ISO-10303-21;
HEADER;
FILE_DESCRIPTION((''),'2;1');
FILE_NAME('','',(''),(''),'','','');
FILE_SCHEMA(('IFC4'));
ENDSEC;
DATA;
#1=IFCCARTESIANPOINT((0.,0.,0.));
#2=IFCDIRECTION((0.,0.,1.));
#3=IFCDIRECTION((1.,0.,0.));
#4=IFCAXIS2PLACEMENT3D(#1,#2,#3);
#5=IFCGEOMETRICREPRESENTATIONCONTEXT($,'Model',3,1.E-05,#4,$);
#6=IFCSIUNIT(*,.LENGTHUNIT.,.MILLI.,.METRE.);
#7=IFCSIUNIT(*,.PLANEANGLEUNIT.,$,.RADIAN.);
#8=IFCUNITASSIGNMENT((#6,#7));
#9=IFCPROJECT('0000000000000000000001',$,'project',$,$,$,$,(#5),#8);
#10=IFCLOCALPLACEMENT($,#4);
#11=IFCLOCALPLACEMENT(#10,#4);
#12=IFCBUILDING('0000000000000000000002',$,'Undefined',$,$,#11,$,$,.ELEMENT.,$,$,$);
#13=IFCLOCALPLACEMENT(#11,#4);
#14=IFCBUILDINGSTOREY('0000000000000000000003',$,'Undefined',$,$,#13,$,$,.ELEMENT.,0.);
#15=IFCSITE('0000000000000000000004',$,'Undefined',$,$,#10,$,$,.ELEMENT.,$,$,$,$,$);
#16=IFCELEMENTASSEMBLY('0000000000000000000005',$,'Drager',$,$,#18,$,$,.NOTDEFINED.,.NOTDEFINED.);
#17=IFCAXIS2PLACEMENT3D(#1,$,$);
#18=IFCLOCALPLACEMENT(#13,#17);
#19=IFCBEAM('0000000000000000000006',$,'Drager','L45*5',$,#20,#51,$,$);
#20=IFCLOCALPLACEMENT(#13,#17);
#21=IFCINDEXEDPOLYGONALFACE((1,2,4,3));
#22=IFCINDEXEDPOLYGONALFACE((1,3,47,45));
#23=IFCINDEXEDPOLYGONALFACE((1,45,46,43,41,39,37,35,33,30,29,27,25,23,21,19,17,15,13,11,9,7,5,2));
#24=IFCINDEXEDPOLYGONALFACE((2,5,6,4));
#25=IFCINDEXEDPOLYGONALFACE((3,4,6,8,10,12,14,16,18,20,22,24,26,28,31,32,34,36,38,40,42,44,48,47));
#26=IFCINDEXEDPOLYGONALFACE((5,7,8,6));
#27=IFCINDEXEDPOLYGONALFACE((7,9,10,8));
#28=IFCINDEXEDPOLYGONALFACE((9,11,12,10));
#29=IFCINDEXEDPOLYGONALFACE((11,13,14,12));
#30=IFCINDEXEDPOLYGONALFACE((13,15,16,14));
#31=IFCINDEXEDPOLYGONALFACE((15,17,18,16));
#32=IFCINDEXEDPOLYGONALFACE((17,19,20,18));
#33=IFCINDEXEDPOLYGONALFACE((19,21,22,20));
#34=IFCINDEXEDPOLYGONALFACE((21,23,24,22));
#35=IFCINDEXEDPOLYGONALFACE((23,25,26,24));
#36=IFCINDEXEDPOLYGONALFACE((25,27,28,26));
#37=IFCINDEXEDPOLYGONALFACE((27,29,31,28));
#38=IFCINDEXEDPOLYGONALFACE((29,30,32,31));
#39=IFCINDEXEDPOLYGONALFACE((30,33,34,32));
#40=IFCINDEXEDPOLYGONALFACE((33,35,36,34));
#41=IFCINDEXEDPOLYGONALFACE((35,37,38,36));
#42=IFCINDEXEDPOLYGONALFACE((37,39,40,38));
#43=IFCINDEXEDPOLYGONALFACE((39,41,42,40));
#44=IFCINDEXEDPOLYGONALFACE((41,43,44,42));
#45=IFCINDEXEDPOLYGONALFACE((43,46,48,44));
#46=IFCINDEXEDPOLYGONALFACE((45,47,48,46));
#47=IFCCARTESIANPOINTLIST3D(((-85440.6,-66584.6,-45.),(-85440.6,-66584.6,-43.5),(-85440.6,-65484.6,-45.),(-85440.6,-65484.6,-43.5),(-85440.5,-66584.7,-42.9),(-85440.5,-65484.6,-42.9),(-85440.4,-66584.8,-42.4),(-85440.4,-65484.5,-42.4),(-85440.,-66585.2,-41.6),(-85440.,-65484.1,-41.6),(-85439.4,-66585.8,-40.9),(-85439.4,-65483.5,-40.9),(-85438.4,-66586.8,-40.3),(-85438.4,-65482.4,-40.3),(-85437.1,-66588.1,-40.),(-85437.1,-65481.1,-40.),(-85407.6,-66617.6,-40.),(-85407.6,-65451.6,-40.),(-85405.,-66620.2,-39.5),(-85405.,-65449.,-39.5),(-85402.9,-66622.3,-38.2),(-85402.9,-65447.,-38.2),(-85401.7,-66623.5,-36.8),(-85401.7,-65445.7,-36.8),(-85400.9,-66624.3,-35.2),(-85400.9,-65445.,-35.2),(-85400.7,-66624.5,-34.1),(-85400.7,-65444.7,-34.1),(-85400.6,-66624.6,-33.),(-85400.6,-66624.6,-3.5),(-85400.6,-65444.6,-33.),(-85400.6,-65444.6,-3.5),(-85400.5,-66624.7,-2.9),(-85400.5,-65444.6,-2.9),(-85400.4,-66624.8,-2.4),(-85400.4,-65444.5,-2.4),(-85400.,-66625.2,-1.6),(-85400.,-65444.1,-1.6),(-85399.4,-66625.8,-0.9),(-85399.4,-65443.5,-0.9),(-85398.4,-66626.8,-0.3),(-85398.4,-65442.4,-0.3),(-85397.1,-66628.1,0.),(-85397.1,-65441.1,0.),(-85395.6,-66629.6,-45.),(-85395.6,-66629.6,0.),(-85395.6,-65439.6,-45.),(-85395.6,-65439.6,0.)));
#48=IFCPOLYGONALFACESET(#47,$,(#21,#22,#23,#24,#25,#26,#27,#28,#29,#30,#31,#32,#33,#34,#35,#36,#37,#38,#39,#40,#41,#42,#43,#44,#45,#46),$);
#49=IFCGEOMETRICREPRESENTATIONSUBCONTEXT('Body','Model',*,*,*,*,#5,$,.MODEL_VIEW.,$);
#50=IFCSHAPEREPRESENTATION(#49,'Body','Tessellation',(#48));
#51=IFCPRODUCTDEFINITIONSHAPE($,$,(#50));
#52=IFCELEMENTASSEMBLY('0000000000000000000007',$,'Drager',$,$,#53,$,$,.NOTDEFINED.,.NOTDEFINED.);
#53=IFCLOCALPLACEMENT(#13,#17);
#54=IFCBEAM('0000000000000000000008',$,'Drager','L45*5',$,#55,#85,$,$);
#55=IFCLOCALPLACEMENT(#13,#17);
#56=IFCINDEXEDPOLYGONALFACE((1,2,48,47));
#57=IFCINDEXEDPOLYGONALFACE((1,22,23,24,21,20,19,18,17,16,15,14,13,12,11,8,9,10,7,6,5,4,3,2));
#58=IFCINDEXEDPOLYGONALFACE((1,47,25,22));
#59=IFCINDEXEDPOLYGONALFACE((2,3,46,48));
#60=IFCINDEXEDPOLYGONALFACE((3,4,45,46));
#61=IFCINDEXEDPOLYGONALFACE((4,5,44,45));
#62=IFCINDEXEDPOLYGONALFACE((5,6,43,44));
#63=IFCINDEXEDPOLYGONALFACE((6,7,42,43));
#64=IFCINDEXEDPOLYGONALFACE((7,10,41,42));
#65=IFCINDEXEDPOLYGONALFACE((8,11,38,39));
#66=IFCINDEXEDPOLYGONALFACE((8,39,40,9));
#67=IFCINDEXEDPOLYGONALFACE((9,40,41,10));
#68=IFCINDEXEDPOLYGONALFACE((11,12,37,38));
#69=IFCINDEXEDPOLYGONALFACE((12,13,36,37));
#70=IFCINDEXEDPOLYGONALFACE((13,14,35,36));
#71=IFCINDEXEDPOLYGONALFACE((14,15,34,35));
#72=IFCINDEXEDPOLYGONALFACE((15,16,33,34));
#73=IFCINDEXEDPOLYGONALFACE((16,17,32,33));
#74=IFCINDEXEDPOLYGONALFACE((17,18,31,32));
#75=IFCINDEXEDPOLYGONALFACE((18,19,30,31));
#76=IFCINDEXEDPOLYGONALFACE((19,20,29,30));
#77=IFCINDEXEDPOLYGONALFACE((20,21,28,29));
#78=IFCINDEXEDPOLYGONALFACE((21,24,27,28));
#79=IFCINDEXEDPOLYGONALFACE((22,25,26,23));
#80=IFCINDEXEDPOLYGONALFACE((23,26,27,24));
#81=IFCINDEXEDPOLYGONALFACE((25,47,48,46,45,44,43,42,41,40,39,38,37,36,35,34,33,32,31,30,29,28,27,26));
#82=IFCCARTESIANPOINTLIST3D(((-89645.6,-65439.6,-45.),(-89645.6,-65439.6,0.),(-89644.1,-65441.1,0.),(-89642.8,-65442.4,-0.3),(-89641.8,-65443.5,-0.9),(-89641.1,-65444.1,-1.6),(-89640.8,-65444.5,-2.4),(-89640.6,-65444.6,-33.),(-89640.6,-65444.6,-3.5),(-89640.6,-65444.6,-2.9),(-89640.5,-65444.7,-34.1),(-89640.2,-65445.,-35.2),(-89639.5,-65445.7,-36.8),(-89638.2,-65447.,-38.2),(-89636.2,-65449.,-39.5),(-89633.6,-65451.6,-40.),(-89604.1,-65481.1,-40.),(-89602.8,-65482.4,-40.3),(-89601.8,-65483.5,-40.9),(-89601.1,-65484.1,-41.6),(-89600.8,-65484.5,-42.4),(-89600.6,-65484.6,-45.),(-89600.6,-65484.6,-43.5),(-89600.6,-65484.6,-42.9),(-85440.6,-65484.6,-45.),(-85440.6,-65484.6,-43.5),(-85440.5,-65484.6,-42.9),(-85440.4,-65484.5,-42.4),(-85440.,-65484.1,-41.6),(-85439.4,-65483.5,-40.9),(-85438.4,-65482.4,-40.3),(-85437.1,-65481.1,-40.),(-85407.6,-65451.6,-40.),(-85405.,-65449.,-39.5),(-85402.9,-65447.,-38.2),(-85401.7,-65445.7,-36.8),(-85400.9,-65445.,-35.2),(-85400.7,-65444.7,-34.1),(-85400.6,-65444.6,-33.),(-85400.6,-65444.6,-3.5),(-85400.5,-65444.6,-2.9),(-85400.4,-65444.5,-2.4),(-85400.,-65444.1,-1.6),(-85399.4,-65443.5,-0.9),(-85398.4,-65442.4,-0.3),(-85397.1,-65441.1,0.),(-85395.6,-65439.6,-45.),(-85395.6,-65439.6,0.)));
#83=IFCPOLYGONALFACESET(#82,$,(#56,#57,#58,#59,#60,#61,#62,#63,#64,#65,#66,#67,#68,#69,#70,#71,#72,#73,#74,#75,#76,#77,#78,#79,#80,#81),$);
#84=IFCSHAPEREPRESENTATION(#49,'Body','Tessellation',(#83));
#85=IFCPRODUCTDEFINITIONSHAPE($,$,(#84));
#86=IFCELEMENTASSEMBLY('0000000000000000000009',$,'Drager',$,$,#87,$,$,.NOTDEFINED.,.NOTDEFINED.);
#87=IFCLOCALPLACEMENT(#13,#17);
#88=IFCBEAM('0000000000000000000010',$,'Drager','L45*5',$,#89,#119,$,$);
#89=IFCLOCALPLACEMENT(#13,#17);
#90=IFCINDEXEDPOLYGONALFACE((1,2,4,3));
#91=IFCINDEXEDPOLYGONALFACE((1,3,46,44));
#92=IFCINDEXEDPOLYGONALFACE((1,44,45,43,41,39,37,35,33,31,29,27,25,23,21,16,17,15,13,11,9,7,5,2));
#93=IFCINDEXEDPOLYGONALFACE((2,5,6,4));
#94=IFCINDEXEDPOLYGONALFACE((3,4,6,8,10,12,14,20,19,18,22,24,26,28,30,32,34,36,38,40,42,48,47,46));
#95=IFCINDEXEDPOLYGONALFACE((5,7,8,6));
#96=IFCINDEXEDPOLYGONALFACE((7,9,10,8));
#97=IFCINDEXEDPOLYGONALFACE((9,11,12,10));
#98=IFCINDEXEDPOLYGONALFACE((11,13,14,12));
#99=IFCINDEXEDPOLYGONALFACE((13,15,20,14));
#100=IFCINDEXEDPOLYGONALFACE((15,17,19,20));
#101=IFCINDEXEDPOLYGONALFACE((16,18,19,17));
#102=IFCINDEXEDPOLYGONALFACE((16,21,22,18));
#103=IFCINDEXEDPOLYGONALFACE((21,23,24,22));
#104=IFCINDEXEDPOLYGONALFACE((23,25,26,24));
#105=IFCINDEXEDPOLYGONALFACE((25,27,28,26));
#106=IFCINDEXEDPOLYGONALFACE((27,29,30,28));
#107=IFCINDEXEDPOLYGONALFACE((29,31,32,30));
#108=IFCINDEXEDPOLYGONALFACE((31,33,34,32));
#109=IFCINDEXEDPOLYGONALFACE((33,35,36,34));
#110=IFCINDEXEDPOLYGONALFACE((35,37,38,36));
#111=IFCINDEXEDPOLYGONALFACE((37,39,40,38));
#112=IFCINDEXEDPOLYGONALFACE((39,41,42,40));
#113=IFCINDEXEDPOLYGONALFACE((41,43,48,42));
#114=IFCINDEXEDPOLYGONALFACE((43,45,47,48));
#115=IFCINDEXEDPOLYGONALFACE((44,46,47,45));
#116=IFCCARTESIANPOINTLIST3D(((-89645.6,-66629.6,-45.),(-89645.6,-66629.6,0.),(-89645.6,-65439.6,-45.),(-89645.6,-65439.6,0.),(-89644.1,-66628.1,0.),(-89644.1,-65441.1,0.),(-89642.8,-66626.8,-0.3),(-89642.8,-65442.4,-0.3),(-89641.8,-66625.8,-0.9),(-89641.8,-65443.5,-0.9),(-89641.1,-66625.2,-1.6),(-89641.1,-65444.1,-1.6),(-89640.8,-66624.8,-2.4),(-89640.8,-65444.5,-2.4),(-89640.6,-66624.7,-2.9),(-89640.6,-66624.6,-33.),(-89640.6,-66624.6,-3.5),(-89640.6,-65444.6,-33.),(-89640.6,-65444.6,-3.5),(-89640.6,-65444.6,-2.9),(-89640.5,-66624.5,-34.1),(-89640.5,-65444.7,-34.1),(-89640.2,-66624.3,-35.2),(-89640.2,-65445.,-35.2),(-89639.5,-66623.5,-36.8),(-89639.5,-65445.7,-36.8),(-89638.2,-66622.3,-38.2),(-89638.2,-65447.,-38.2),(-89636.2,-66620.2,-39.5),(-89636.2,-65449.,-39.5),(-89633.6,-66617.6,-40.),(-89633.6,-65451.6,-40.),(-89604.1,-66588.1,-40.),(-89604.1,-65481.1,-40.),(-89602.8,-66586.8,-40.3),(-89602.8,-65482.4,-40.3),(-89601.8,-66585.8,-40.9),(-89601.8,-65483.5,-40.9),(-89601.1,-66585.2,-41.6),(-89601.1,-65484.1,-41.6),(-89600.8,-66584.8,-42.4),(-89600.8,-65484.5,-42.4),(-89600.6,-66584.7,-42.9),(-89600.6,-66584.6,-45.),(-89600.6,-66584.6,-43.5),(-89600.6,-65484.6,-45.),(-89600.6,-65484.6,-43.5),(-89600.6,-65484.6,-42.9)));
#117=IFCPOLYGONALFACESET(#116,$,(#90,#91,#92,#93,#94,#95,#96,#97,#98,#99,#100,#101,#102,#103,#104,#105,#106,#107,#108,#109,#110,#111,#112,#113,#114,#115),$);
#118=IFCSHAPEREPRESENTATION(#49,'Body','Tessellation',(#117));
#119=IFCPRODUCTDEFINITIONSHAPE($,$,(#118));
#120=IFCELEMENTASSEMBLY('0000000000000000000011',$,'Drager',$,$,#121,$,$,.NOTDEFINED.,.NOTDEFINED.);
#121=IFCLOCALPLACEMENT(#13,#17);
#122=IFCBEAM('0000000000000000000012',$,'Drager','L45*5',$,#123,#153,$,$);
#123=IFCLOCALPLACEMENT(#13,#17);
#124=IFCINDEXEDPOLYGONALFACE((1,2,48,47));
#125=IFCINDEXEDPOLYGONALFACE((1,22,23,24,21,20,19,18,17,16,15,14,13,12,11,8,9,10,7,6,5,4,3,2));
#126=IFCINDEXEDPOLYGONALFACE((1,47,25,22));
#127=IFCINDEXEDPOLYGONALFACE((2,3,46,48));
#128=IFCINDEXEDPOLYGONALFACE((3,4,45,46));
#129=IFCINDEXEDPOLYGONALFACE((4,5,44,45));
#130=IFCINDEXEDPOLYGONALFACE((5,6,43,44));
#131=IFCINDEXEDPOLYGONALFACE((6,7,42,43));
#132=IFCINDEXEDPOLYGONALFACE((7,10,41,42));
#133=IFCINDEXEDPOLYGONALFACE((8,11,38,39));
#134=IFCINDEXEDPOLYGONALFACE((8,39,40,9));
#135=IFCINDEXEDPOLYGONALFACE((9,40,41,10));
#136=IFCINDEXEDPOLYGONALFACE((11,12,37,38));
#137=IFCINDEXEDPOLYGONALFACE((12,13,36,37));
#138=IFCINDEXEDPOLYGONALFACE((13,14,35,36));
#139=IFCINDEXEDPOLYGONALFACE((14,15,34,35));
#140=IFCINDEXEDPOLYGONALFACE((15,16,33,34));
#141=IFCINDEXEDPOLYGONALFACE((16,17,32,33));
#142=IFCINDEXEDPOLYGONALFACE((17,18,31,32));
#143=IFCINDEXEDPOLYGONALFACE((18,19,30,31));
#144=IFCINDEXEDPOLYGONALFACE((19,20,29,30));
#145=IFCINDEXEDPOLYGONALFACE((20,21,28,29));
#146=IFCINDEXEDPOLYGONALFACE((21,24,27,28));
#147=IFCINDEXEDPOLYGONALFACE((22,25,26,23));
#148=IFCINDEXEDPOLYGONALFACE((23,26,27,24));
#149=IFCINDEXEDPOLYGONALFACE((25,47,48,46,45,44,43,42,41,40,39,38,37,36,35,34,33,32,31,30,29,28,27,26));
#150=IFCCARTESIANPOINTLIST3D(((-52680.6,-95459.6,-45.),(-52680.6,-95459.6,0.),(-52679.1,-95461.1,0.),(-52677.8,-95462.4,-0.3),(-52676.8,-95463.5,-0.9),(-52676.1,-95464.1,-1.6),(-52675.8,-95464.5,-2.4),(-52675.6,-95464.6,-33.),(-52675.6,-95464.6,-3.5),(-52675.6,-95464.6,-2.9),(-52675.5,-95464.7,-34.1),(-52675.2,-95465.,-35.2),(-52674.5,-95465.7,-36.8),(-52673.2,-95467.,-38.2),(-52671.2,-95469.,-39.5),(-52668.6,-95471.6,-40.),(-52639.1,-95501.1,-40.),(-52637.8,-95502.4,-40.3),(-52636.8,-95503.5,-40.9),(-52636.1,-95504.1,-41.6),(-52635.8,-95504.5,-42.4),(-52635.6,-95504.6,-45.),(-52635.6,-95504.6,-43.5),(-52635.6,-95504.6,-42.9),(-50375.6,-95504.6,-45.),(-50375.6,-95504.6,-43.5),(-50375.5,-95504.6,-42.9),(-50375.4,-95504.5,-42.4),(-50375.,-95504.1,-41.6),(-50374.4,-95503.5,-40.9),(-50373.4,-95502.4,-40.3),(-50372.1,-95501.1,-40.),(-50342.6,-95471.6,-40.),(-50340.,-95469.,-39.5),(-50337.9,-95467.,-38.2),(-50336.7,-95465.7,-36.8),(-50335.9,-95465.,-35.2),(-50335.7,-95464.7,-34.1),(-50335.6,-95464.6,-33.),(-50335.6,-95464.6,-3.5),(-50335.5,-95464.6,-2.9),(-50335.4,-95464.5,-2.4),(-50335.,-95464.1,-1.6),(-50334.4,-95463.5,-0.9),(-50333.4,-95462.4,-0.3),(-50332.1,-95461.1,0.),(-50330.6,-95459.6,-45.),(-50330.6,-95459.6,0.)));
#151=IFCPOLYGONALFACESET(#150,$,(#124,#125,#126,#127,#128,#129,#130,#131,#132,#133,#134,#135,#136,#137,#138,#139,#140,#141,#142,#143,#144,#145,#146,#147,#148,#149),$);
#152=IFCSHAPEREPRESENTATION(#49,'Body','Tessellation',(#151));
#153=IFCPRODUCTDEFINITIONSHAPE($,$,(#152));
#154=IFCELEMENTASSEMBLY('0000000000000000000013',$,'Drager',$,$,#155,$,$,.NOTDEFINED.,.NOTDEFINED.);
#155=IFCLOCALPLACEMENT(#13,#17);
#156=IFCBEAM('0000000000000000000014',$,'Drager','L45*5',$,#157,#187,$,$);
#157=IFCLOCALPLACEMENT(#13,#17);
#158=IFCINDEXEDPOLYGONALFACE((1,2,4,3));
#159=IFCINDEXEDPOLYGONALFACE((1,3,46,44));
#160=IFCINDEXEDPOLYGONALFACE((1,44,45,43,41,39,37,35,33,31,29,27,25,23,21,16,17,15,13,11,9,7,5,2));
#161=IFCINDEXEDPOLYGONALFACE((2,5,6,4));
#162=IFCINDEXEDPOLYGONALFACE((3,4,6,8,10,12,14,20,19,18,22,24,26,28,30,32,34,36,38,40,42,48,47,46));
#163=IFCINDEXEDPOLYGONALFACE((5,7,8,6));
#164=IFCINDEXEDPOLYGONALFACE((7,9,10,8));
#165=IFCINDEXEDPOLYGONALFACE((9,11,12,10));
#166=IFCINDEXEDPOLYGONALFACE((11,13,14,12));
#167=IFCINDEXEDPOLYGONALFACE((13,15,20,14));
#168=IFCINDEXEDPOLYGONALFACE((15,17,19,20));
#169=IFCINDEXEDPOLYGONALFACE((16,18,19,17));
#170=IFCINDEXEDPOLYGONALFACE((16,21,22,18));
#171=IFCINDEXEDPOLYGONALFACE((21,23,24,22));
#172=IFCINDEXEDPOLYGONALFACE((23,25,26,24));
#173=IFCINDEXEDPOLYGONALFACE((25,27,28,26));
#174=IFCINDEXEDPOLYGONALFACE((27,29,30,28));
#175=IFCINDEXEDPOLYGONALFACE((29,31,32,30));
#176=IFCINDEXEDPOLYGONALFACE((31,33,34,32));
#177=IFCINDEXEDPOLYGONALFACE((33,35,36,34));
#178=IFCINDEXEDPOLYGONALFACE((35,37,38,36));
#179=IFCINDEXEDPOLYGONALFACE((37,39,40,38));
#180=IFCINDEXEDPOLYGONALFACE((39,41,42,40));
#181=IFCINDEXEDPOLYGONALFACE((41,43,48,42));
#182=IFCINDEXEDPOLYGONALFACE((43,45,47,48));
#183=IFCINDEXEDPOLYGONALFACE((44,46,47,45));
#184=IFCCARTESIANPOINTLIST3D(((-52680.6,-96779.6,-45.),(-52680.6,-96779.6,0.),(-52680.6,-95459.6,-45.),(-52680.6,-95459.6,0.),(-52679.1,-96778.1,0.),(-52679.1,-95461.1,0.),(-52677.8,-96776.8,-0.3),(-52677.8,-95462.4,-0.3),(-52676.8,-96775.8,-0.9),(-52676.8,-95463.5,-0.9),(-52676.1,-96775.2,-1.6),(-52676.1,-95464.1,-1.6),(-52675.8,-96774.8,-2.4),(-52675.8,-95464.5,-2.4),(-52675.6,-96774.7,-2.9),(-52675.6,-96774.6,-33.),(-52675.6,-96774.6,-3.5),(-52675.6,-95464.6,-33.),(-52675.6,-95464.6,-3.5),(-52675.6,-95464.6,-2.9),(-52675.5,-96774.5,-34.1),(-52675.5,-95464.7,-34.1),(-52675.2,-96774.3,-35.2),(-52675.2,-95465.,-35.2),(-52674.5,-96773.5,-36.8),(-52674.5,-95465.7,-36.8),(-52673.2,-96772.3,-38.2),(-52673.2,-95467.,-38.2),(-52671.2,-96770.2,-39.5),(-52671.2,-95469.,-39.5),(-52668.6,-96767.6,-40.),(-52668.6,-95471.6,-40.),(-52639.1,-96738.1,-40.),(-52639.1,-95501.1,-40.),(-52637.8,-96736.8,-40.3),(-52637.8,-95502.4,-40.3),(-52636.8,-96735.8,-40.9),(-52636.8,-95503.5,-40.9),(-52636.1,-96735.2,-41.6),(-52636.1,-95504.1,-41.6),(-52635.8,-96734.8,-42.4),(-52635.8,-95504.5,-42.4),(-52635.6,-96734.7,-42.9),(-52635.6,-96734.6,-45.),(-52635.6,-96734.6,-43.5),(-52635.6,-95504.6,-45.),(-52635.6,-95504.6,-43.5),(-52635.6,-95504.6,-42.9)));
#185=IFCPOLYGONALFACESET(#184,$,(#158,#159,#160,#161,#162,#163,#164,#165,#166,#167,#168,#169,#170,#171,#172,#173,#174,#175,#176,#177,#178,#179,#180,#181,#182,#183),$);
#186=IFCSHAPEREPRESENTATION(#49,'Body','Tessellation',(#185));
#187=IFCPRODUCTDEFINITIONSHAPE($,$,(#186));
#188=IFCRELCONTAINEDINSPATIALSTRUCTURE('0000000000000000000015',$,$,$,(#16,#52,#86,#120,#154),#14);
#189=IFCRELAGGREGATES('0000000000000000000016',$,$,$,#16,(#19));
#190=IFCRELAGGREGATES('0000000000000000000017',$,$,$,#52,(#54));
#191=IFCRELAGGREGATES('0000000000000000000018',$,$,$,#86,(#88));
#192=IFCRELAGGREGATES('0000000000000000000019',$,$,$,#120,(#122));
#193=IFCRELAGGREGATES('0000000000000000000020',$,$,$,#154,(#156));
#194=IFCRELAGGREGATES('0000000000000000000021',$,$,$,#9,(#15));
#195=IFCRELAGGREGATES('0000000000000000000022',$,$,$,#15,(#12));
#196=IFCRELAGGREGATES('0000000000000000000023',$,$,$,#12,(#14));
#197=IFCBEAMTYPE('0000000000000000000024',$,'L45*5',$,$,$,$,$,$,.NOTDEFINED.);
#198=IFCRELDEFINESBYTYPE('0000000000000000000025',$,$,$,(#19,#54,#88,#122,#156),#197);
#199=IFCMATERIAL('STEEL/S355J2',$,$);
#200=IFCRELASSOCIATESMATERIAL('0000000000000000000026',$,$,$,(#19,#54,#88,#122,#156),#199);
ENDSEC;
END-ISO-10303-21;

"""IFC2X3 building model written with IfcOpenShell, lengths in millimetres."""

from ifc_helpers import new_model, si_unit, frame, origin_with_axes, origin_2d_with_axis, place, context, subcontext, project, spatial, l_section, extrude, clip, halfspace, material, type_object, element, aggregate, save


model = new_model("IFC2X3")

# Units and contexts
model_context = context("Model", 3, precision=1e-05, world=origin_with_axes())
body_context = subcontext(model_context, "Body", "Model", "MODEL_VIEW")
ifc_project = project(units=[si_unit("LENGTHUNIT", "METRE", prefix="MILLI"), si_unit("PLANEANGLEUNIT", "RADIAN")], contexts=[model_context])

# Site, building, storey
site_placement = place(None, origin_with_axes())
site = spatial("IfcSite", under=ifc_project, at=site_placement, Name="Undefined", CompositionType="ELEMENT")
building_placement = place(site_placement, origin_with_axes())
building = spatial("IfcBuilding", under=site, at=building_placement, Name="Undefined", CompositionType="ELEMENT")
storey_placement = place(building_placement, origin_with_axes())
storey = spatial("IfcBuildingStorey", under=building, at=storey_placement, Name="Undefined", CompositionType="ELEMENT", Elevation=0.0)

# Shared definitions
ifc_material_1 = material(Name="STEEL/S355J2")

# Element assemblies, beams
beam_type_1 = type_object("IfcBeamType", Name="L45*5", PredefinedType="NOTDEFINED")
assembly_1_placement = place(storey_placement, origin_with_axes())
assembly_1 = element("IfcElementAssembly", 1, at=assembly_1_placement, inside=storey, Name="Drager", AssemblyPlace="NOTDEFINED", PredefinedType="NOTDEFINED")
beam_1_placement = place(assembly_1_placement, frame((-85418.1, -65484.6, -22.5), z_axis=(0.0, 0.0, 1.0), x_axis=(0.0, -1.0, 0.0)))
beam_1 = element("IfcBeam", 2, at=beam_1_placement, type_object=beam_type_1, material=ifc_material_1, Name="Drager", Description="L45*5", context=body_context, shape_type="Clipping", body=[
    clip(clip(extrude(l_section(Depth=45.0, Width=45.0, Thickness=5.0, FilletRadius=7.0, EdgeRadius=3.5, at=origin_2d_with_axis()), frame((1167.9, 0.0, 0.0), z_axis=(-1.0, 0.0, 0.0), x_axis=(0.0, -1.0, 0.0)), (0.0, 0.0, 1.0), 1235.9), halfspace(frame((1100.0, -22.5, 22.5), z_axis=(0.707107, -0.707107, 0.0), x_axis=(0.0, 0.0, 1.0)), False)), halfspace(frame((0.0, -22.5, 22.5), z_axis=(0.707107, 0.707107, 0.0), x_axis=(0.0, 0.0, 1.0)), True)),
])
aggregate(assembly_1, [beam_1])
assembly_2_placement = place(storey_placement, origin_with_axes())
assembly_2 = element("IfcElementAssembly", 3, at=assembly_2_placement, inside=storey, Name="Drager", AssemblyPlace="NOTDEFINED", PredefinedType="NOTDEFINED")
beam_2_placement = place(assembly_2_placement, frame((-89600.6, -65462.1, -22.5), z_axis=(0.0, 0.0, 1.0), x_axis=(1.0, 0.0, 0.0)))
beam_2 = element("IfcBeam", 4, at=beam_2_placement, type_object=beam_type_1, material=ifc_material_1, Name="Drager", Description="L45*5", context=body_context, shape_type="Clipping", body=[
    clip(clip(extrude(l_section(Depth=45.0, Width=45.0, Thickness=5.0, FilletRadius=7.0, EdgeRadius=3.5, at=origin_2d_with_axis()), frame((4227.9, 0.0, 0.0), z_axis=(-1.0, 0.0, 0.0), x_axis=(0.0, -1.0, 0.0)), (0.0, 0.0, 1.0), 4295.9), halfspace(frame((4160.0, -22.5, 22.5), z_axis=(0.707107, -0.707107, 0.0), x_axis=(0.0, 0.0, 1.0)), False)), halfspace(frame((0.0, -22.5, 22.5), z_axis=(0.707107, 0.707107, 0.0), x_axis=(0.0, 0.0, 1.0)), True)),
])
aggregate(assembly_2, [beam_2])
assembly_3_placement = place(storey_placement, origin_with_axes())
assembly_3 = element("IfcElementAssembly", 5, at=assembly_3_placement, inside=storey, Name="Drager", AssemblyPlace="NOTDEFINED", PredefinedType="NOTDEFINED")
beam_3_placement = place(assembly_3_placement, frame((-89623.1, -66584.6, -22.5), z_axis=(0.0, 0.0, 1.0), x_axis=(0.0, 1.0, 0.0)))
beam_3 = element("IfcBeam", 6, at=beam_3_placement, type_object=beam_type_1, material=ifc_material_1, Name="Drager", Description="L45*5", context=body_context, shape_type="Clipping", body=[
    clip(clip(extrude(l_section(Depth=45.0, Width=45.0, Thickness=5.0, FilletRadius=7.0, EdgeRadius=3.5, at=origin_2d_with_axis()), frame((1167.9, 0.0, 0.0), z_axis=(-1.0, 0.0, 0.0), x_axis=(0.0, -1.0, 0.0)), (0.0, 0.0, 1.0), 1235.9), halfspace(frame((1100.0, -22.5, 22.5), z_axis=(0.707107, -0.707107, 0.0), x_axis=(0.0, 0.0, 1.0)), False)), halfspace(frame((0.0, -22.5, 22.5), z_axis=(0.707107, 0.707107, 0.0), x_axis=(0.0, 0.0, 1.0)), True)),
])
aggregate(assembly_3, [beam_3])
assembly_4_placement = place(storey_placement, origin_with_axes())
assembly_4 = element("IfcElementAssembly", 7, at=assembly_4_placement, inside=storey, Name="Drager", AssemblyPlace="NOTDEFINED", PredefinedType="NOTDEFINED")
beam_4_placement = place(assembly_4_placement, frame((-52635.6, -95482.1, -22.5), z_axis=(0.0, 0.0, 1.0), x_axis=(1.0, 0.0, 0.0)))
beam_4 = element("IfcBeam", 8, at=beam_4_placement, type_object=beam_type_1, material=ifc_material_1, Name="Drager", Description="L45*5", context=body_context, shape_type="Clipping", body=[
    clip(clip(extrude(l_section(Depth=45.0, Width=45.0, Thickness=5.0, FilletRadius=7.0, EdgeRadius=3.5, at=origin_2d_with_axis()), frame((2327.9, 0.0, 0.0), z_axis=(-1.0, 0.0, 0.0), x_axis=(0.0, -1.0, 0.0)), (0.0, 0.0, 1.0), 2395.9), halfspace(frame((2260.0, -22.5, 22.5), z_axis=(0.707107, -0.707106, 0.0), x_axis=(0.0, 0.0, 1.0)), False)), halfspace(frame((0.0, -22.5, 22.5), z_axis=(0.707107, 0.707107, 0.0), x_axis=(0.0, 0.0, 1.0)), True)),
])
aggregate(assembly_4, [beam_4])
assembly_5_placement = place(storey_placement, origin_with_axes())
assembly_5 = element("IfcElementAssembly", 9, at=assembly_5_placement, inside=storey, Name="Drager", AssemblyPlace="NOTDEFINED", PredefinedType="NOTDEFINED")
beam_5_placement = place(assembly_5_placement, frame((-52658.1, -96734.6, -22.5), z_axis=(0.0, 0.0, 1.0), x_axis=(0.0, 1.0, 0.0)))
beam_5 = element("IfcBeam", 10, at=beam_5_placement, type_object=beam_type_1, material=ifc_material_1, Name="Drager", Description="L45*5", context=body_context, shape_type="Clipping", body=[
    clip(clip(extrude(l_section(Depth=45.0, Width=45.0, Thickness=5.0, FilletRadius=7.0, EdgeRadius=3.5, at=origin_2d_with_axis()), frame((1297.9, 0.0, 0.0), z_axis=(-1.0, 0.0, 0.0), x_axis=(0.0, -1.0, 0.0)), (0.0, 0.0, 1.0), 1365.9), halfspace(frame((1230.0, -22.5, 22.5), z_axis=(0.707107, -0.707107, 0.0), x_axis=(0.0, 0.0, 1.0)), False)), halfspace(frame((0.0, -22.5, 22.5), z_axis=(0.707107, 0.707107, 0.0), x_axis=(0.0, 0.0, 1.0)), True)),
])
aggregate(assembly_5, [beam_5])

save(model, "model.ifc")
